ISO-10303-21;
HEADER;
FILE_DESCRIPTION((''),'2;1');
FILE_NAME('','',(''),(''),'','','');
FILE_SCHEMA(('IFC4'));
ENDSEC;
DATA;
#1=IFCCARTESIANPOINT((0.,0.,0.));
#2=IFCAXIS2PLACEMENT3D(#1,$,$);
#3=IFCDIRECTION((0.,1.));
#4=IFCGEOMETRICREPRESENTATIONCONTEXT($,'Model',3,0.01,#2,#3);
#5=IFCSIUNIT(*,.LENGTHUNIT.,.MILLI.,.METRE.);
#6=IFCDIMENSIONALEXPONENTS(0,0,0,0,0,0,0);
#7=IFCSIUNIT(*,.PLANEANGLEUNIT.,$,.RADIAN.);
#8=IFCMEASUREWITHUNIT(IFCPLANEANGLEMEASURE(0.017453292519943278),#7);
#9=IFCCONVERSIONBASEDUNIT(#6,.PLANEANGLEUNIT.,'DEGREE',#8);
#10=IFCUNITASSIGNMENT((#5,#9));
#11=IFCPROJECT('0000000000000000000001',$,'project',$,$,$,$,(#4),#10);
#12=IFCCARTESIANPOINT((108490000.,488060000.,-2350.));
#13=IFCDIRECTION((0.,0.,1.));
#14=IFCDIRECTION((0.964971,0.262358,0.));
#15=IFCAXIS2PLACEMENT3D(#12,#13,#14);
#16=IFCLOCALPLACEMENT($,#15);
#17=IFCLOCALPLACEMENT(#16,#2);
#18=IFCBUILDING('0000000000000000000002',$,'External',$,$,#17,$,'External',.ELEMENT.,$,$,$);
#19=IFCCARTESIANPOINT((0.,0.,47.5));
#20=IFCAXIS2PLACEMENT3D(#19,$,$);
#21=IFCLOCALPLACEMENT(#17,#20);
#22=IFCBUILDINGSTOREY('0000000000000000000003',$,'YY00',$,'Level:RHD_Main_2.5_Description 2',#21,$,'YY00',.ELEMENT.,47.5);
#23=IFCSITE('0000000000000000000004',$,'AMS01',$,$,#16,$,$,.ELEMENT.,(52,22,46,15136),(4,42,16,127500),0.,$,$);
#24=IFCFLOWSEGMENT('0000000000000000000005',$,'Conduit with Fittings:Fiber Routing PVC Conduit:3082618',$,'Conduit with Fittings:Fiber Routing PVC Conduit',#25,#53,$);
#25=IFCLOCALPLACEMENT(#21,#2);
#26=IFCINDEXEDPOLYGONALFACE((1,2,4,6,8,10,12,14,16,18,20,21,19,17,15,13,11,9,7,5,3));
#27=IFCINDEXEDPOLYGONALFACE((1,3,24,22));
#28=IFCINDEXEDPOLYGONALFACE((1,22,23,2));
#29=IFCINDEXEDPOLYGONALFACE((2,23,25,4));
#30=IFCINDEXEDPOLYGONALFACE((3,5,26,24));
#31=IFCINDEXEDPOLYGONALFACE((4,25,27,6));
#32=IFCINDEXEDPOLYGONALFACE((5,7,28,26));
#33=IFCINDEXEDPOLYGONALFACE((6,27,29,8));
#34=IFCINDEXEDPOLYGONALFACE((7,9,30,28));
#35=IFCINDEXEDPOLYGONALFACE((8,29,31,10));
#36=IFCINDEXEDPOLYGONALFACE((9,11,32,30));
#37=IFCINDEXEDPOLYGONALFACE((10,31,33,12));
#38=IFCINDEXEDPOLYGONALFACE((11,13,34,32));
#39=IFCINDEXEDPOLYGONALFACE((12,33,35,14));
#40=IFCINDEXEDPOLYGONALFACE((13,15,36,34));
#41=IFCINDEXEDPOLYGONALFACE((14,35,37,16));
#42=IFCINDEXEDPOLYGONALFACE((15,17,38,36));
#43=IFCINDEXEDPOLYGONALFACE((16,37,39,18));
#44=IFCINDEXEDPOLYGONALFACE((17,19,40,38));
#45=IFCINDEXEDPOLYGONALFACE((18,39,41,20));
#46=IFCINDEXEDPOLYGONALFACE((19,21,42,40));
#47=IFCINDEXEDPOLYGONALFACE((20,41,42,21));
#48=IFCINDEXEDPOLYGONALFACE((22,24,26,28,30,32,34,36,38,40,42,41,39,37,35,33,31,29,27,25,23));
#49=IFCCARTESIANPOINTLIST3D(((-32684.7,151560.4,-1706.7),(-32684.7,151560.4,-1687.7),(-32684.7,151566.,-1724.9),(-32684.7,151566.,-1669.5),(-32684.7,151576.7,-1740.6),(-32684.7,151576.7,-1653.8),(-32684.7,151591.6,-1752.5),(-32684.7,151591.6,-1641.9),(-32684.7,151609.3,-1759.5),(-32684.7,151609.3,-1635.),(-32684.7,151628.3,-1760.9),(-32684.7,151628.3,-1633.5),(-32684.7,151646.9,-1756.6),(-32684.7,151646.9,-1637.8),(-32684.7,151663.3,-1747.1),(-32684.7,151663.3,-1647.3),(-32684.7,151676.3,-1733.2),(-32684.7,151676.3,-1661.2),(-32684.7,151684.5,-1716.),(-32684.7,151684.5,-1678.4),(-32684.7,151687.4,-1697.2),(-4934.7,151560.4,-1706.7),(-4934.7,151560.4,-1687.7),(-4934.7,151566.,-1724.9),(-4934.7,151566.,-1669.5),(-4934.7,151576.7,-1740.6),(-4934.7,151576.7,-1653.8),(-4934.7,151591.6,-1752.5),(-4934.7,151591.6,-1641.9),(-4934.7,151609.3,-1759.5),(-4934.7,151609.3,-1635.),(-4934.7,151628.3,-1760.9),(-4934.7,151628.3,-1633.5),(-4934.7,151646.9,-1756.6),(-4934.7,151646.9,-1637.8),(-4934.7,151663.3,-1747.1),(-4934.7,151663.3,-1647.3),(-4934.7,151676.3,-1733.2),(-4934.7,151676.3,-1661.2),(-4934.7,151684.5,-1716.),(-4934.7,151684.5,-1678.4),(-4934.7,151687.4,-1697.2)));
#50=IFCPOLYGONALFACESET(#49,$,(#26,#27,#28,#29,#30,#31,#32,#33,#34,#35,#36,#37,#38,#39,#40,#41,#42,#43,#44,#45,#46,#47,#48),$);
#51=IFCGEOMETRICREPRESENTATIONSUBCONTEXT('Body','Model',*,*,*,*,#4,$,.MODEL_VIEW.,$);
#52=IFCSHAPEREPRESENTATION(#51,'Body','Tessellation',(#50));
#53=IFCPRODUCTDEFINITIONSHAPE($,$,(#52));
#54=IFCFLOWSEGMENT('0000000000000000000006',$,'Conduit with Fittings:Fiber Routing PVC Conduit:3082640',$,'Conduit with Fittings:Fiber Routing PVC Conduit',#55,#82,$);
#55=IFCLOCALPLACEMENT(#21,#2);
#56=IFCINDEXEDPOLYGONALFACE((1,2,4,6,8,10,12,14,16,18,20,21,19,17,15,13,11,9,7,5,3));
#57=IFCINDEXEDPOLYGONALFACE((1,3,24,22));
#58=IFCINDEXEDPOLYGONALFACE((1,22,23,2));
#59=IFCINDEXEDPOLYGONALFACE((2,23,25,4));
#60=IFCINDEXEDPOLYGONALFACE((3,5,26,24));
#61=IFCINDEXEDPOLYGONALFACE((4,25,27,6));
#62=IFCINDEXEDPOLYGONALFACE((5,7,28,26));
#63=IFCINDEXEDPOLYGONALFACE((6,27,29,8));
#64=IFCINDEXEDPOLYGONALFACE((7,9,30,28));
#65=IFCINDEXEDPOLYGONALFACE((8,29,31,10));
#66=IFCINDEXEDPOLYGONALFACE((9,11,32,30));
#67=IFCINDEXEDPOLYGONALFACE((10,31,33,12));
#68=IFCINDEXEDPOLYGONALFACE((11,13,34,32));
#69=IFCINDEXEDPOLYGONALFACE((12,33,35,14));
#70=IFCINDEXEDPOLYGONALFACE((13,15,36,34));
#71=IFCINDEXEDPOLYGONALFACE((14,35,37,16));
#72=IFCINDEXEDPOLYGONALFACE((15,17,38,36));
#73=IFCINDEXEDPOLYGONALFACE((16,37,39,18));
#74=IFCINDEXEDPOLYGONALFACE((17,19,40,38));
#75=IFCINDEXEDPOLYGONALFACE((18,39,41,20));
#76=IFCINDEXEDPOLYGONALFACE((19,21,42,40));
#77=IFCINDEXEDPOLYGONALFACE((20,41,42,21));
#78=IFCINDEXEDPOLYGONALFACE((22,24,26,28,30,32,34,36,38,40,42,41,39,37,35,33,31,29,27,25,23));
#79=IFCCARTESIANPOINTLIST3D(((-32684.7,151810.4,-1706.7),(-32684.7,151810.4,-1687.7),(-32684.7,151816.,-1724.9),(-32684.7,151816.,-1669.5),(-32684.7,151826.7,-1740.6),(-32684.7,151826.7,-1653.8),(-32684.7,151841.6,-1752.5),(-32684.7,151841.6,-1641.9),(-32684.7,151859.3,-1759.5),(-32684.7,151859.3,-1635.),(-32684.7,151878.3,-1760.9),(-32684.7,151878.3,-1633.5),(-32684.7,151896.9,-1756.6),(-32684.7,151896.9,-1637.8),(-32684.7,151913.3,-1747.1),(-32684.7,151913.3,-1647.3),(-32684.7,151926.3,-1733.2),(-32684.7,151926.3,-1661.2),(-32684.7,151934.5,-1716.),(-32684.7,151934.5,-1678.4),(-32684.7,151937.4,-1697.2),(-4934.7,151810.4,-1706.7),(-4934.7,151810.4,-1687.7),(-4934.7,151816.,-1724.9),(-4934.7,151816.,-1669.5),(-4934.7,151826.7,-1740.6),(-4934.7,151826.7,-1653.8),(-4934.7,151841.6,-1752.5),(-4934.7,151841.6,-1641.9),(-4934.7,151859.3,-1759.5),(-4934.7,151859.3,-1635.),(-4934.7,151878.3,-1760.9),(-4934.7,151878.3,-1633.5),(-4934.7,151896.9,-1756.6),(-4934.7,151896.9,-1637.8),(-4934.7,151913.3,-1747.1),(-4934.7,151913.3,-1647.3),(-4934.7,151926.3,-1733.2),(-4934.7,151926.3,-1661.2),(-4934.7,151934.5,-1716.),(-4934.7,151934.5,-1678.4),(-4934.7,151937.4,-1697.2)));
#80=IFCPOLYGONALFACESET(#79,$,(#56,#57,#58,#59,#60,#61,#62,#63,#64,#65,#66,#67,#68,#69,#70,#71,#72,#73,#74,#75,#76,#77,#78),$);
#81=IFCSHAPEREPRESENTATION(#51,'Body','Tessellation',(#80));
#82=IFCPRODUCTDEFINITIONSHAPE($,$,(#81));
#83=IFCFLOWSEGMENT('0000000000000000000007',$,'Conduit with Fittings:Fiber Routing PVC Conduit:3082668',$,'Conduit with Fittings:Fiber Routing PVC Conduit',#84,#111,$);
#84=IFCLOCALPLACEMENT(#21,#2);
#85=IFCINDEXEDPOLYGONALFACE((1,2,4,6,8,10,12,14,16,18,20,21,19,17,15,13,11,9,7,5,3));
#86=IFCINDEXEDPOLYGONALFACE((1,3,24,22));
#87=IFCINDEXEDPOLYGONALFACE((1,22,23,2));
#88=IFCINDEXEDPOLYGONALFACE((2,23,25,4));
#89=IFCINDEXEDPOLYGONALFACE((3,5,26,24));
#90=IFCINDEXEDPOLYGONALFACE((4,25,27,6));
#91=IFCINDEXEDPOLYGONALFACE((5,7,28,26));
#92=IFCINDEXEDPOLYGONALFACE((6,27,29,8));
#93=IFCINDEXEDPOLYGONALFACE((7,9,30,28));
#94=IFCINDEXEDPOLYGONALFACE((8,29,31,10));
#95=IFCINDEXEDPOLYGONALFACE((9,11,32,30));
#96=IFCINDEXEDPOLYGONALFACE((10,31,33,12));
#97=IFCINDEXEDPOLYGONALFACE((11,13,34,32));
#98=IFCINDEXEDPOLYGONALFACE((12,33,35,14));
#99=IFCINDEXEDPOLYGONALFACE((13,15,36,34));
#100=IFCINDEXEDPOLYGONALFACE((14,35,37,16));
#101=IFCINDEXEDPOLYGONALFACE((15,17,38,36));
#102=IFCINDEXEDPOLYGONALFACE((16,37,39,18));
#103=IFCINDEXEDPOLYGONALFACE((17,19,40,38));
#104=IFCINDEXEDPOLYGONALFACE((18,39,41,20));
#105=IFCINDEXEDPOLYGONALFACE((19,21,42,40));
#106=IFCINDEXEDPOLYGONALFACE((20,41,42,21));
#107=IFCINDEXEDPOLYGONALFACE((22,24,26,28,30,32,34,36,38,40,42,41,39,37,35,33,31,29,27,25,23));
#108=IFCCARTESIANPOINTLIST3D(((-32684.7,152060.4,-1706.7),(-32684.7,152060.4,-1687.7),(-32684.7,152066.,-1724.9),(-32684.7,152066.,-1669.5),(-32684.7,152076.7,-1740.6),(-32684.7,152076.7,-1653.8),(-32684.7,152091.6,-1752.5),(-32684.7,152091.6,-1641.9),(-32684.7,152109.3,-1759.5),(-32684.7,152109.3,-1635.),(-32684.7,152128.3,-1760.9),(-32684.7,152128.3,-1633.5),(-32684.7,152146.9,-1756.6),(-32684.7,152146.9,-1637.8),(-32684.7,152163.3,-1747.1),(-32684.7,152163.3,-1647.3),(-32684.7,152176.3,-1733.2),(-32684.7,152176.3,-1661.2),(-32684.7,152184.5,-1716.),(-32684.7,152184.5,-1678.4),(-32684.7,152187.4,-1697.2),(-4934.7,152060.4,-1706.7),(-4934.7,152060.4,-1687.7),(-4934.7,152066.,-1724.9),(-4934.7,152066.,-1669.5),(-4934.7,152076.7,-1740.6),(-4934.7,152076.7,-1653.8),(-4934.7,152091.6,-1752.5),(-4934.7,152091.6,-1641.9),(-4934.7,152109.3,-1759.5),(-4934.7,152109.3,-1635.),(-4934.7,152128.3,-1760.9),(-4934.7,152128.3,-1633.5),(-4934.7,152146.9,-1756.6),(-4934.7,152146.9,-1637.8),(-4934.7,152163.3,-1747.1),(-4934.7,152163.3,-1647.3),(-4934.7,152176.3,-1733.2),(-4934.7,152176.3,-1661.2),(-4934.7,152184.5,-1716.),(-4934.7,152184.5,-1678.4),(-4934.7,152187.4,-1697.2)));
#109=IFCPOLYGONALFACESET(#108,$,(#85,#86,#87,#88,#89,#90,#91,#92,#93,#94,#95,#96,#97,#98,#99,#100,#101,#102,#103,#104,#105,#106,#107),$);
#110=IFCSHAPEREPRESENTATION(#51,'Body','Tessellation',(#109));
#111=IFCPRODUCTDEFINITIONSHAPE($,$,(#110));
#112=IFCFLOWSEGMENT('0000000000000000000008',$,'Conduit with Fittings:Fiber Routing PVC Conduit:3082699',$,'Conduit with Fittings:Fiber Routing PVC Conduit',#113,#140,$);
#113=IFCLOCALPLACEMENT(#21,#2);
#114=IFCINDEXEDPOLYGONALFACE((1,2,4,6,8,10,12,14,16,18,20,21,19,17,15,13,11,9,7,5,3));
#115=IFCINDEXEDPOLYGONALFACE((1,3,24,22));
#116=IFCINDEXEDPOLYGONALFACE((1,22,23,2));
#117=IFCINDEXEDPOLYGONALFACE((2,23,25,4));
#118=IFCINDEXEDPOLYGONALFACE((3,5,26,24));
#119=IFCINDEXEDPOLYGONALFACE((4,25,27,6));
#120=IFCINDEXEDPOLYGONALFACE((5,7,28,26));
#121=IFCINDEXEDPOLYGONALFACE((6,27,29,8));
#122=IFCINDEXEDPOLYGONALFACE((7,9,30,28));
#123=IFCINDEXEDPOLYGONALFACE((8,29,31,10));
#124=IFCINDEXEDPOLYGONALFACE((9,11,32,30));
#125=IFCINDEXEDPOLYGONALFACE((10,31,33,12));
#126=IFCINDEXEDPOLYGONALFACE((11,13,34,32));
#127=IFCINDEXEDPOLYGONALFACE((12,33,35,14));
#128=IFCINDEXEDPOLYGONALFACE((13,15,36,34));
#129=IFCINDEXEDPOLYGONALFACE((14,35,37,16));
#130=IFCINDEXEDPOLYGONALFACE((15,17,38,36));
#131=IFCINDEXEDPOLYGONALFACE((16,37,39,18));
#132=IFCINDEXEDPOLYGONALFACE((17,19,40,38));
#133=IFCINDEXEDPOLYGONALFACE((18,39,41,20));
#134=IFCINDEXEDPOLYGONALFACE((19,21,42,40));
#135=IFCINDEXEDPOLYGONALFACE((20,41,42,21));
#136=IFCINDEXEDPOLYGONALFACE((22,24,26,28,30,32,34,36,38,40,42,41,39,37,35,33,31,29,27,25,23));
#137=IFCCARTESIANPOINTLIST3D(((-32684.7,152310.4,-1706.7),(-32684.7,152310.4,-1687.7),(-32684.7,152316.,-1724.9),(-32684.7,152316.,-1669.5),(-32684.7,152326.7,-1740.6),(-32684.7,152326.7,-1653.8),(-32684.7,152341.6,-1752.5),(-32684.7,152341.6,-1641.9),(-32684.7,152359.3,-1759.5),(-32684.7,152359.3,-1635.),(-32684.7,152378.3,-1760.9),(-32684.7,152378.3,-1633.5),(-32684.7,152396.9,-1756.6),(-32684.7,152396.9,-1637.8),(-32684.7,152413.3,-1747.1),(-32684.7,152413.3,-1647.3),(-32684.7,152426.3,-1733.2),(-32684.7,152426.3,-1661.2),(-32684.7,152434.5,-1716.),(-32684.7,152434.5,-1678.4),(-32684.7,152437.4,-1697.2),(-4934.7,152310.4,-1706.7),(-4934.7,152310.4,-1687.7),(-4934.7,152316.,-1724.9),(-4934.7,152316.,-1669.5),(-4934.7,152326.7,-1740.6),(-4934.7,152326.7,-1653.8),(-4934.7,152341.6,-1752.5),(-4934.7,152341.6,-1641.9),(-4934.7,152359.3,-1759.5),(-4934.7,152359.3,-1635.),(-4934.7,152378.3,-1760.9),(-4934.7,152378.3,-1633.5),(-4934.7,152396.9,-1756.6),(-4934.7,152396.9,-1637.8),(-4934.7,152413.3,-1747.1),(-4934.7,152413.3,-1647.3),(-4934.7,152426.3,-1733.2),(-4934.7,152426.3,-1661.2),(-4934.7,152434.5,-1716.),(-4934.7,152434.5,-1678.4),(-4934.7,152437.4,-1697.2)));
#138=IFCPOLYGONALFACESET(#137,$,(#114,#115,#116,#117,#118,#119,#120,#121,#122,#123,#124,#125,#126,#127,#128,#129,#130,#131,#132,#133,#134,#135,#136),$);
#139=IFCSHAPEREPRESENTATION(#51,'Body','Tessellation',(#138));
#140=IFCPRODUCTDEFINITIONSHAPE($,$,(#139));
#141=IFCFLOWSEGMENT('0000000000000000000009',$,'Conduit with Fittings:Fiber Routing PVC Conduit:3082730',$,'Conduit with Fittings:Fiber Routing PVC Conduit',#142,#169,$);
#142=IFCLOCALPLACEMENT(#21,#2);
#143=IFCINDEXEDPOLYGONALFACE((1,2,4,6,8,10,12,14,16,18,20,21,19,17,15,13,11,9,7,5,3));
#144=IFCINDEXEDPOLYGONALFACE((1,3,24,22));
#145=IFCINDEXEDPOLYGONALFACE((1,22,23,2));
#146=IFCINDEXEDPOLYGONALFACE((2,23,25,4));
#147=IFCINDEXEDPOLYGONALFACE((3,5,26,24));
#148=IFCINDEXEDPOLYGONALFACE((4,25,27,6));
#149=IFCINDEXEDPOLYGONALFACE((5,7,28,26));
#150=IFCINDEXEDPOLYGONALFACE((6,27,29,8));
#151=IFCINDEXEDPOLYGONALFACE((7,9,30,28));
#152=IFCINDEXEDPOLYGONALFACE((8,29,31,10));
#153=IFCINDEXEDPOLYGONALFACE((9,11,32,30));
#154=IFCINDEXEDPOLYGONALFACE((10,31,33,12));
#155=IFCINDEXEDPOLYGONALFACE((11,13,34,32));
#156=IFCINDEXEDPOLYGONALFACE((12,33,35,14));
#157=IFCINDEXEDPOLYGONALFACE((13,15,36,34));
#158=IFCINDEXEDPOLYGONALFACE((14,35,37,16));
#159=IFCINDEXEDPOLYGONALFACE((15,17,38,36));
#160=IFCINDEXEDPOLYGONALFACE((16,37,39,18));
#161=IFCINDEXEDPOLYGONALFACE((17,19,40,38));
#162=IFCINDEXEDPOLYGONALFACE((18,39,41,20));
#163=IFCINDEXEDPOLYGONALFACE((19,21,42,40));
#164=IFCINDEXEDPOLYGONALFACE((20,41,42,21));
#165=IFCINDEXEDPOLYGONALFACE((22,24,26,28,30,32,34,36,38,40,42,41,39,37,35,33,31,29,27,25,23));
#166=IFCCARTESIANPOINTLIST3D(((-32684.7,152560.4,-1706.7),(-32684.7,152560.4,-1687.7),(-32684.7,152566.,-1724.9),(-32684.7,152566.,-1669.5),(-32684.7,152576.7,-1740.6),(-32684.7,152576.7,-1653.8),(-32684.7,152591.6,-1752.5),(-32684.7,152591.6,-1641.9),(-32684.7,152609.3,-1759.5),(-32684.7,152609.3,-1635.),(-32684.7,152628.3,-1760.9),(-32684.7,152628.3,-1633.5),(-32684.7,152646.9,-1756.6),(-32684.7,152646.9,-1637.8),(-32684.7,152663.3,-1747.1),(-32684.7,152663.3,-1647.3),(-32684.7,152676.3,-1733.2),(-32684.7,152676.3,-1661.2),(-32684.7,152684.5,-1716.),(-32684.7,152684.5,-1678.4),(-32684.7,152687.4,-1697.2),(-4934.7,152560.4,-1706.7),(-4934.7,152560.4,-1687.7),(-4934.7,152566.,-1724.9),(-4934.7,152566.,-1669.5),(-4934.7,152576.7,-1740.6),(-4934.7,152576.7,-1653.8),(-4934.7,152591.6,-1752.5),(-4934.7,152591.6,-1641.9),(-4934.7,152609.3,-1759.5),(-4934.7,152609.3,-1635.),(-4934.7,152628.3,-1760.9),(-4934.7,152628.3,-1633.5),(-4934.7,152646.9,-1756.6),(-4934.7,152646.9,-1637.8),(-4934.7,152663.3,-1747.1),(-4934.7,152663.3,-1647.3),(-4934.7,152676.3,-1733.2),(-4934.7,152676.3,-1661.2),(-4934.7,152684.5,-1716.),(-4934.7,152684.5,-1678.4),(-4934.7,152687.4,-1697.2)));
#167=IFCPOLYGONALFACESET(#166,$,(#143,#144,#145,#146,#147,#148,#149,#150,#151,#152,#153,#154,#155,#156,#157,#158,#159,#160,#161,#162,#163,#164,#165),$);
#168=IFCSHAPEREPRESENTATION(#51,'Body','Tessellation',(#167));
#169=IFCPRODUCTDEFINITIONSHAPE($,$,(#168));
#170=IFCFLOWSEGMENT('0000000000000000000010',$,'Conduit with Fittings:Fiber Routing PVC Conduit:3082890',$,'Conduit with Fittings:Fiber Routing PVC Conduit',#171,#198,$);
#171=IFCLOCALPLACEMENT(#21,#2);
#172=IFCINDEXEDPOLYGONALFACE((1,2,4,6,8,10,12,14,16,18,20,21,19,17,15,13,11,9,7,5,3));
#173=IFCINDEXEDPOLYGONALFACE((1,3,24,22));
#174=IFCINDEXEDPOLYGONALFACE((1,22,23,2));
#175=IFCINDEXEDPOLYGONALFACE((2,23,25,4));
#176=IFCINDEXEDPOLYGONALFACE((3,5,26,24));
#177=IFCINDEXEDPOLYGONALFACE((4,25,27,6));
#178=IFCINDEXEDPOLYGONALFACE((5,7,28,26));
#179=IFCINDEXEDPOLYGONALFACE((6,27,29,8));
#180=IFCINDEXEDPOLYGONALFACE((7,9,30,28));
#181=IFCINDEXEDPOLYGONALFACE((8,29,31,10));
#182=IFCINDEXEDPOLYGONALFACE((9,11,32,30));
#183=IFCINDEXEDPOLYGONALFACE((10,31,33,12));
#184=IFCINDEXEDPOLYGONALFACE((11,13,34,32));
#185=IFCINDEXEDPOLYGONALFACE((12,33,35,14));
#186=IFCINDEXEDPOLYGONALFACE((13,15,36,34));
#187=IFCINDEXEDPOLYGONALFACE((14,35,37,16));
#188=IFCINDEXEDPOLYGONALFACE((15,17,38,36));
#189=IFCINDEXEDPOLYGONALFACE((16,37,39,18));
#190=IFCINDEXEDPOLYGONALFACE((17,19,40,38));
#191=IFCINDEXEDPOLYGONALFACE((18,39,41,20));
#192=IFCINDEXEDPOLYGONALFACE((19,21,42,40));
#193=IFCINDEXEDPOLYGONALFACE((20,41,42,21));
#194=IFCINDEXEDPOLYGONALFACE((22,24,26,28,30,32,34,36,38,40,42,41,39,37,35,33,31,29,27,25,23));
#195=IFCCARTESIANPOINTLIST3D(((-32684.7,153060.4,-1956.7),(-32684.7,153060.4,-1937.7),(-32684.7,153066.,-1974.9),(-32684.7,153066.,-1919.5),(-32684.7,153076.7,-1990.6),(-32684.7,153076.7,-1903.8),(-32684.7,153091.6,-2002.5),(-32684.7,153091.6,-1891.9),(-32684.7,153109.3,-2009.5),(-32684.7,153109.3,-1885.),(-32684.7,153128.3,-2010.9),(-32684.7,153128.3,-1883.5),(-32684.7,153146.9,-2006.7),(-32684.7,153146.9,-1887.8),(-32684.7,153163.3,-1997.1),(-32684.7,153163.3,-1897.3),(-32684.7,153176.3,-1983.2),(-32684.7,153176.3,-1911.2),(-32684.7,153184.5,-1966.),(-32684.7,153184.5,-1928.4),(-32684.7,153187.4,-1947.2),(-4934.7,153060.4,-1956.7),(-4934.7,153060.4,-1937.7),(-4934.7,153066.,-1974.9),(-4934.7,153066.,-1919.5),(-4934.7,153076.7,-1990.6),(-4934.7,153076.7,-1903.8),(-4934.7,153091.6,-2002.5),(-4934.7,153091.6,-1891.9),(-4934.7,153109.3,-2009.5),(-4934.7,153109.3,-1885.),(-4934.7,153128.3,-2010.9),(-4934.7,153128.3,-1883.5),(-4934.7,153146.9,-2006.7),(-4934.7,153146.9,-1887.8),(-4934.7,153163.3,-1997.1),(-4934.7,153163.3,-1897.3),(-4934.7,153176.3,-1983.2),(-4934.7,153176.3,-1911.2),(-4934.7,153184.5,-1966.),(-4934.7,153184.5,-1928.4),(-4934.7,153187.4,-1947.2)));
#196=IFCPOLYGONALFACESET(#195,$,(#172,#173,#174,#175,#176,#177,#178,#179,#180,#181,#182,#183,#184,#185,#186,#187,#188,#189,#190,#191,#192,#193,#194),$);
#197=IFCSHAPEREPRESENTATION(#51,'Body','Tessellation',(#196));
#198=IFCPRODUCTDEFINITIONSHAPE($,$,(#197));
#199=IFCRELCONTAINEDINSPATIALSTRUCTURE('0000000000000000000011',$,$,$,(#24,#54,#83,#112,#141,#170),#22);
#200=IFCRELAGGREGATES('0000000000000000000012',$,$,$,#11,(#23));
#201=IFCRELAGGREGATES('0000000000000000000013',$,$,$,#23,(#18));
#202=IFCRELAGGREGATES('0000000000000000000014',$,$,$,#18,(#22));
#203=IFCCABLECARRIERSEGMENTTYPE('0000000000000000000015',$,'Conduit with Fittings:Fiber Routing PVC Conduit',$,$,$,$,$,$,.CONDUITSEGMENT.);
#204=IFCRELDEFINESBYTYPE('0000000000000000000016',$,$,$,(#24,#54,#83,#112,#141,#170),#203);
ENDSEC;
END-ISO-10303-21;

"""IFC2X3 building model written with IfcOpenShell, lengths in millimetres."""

from ifc_helpers import new_model, entity, si_unit, converted_unit, direction, frame, frame_2d, origin, place, context, subcontext, project, spatial, circle, extrude, type_object, element, save


model = new_model("IFC2X3")

# Units and contexts
model_context = context("Model", 3, precision=0.01, world=origin(), true_north=direction((0.0, 1.0)))
body_context = subcontext(model_context, "Body", "Model", "MODEL_VIEW")
ifc_project = project(units=[si_unit("LENGTHUNIT", "METRE", prefix="MILLI"), converted_unit("PLANEANGLEUNIT", "DEGREE", entity("IfcPlaneAngleMeasure", 0.017453292519943278), si_unit("PLANEANGLEUNIT", "RADIAN"), dimensions=[0, 0, 0, 0, 0, 0, 0])], contexts=[model_context])

# Site, building, storey
site_placement = place(None, frame((108490000.0, 488060000.0, -2350.0), z_axis=(0.0, 0.0, 1.0), x_axis=(0.964971, 0.262358, 0.0)))
site = spatial("IfcSite", under=ifc_project, at=site_placement, Name="AMS01", CompositionType="ELEMENT", RefLatitude=(52, 22, 46, 15136), RefLongitude=(4, 42, 16, 127500), RefElevation=0.0)
building_placement = place(site_placement, origin())
building = spatial("IfcBuilding", under=site, at=building_placement, Name="External", LongName="External", CompositionType="ELEMENT")
storey_placement = place(building_placement, frame((0.0, 0.0, 47.5)))
storey = spatial("IfcBuildingStorey", under=building, at=storey_placement, Name="YY00", ObjectType="Level:RHD_Main_2.5_Description 2", LongName="YY00", CompositionType="ELEMENT", Elevation=47.5)

# Flow segments
cable_carrier_segment_type = type_object("IfcCableCarrierSegmentType", Name="Conduit with Fittings:Fiber Routing PVC Conduit", PredefinedType="CONDUITSEGMENT")
flow_segment_1_placement = place(storey_placement, origin())
element("IfcFlowSegment", 1, at=flow_segment_1_placement, inside=storey, type_object=cable_carrier_segment_type, Name="Conduit with Fittings:Fiber Routing PVC Conduit:3082618", ObjectType="Conduit with Fittings:Fiber Routing PVC Conduit", context=body_context, shape_type="SweptSolid", body=[
    extrude(circle(Radius=63.9, at=frame_2d((0.0, 0.0), x_axis=(1.0, 0.0))), frame((-32684.7, 151623.5, -1697.2), z_axis=(1.0, 0.0, 0.0), x_axis=(0.0, 1.0, 0.0)), (0.0, 0.0, 1.0), 27750.0),
])
flow_segment_2_placement = place(storey_placement, origin())
element("IfcFlowSegment", 2, at=flow_segment_2_placement, inside=storey, type_object=cable_carrier_segment_type, Name="Conduit with Fittings:Fiber Routing PVC Conduit:3082640", ObjectType="Conduit with Fittings:Fiber Routing PVC Conduit", context=body_context, shape_type="SweptSolid", body=[
    extrude(circle(Radius=63.9, at=frame_2d((0.0, 0.0), x_axis=(1.0, 0.0))), frame((-32684.7, 151873.5, -1697.2), z_axis=(1.0, 0.0, 0.0), x_axis=(0.0, 1.0, 0.0)), (0.0, 0.0, 1.0), 27750.0),
])
flow_segment_3_placement = place(storey_placement, origin())
element("IfcFlowSegment", 3, at=flow_segment_3_placement, inside=storey, type_object=cable_carrier_segment_type, Name="Conduit with Fittings:Fiber Routing PVC Conduit:3082668", ObjectType="Conduit with Fittings:Fiber Routing PVC Conduit", context=body_context, shape_type="SweptSolid", body=[
    extrude(circle(Radius=63.9, at=frame_2d((0.0, 0.0), x_axis=(1.0, 0.0))), frame((-32684.7, 152123.5, -1697.2), z_axis=(1.0, 0.0, 0.0), x_axis=(0.0, 1.0, 0.0)), (0.0, 0.0, 1.0), 27750.0),
])
flow_segment_4_placement = place(storey_placement, origin())
element("IfcFlowSegment", 4, at=flow_segment_4_placement, inside=storey, type_object=cable_carrier_segment_type, Name="Conduit with Fittings:Fiber Routing PVC Conduit:3082699", ObjectType="Conduit with Fittings:Fiber Routing PVC Conduit", context=body_context, shape_type="SweptSolid", body=[
    extrude(circle(Radius=63.9, at=frame_2d((0.0, 0.0), x_axis=(1.0, 0.0))), frame((-32684.7, 152373.5, -1697.2), z_axis=(1.0, 0.0, 0.0), x_axis=(0.0, 1.0, 0.0)), (0.0, 0.0, 1.0), 27750.0),
])
flow_segment_5_placement = place(storey_placement, origin())
element("IfcFlowSegment", 5, at=flow_segment_5_placement, inside=storey, type_object=cable_carrier_segment_type, Name="Conduit with Fittings:Fiber Routing PVC Conduit:3082730", ObjectType="Conduit with Fittings:Fiber Routing PVC Conduit", context=body_context, shape_type="SweptSolid", body=[
    extrude(circle(Radius=63.9, at=frame_2d((0.0, 0.0), x_axis=(1.0, 0.0))), frame((-32684.7, 152623.5, -1697.2), z_axis=(1.0, 0.0, 0.0), x_axis=(0.0, 1.0, 0.0)), (0.0, 0.0, 1.0), 27750.0),
])
flow_segment_6_placement = place(storey_placement, origin())
element("IfcFlowSegment", 6, at=flow_segment_6_placement, inside=storey, type_object=cable_carrier_segment_type, Name="Conduit with Fittings:Fiber Routing PVC Conduit:3082890", ObjectType="Conduit with Fittings:Fiber Routing PVC Conduit", context=body_context, shape_type="SweptSolid", body=[
    extrude(circle(Radius=63.9, at=frame_2d((0.0, 0.0), x_axis=(1.0, 0.0))), frame((-32684.7, 153123.5, -1947.2), z_axis=(1.0, 0.0, 0.0), x_axis=(0.0, 1.0, 0.0)), (0.0, 0.0, 1.0), 27750.0),
])

save(model, "model.ifc")
